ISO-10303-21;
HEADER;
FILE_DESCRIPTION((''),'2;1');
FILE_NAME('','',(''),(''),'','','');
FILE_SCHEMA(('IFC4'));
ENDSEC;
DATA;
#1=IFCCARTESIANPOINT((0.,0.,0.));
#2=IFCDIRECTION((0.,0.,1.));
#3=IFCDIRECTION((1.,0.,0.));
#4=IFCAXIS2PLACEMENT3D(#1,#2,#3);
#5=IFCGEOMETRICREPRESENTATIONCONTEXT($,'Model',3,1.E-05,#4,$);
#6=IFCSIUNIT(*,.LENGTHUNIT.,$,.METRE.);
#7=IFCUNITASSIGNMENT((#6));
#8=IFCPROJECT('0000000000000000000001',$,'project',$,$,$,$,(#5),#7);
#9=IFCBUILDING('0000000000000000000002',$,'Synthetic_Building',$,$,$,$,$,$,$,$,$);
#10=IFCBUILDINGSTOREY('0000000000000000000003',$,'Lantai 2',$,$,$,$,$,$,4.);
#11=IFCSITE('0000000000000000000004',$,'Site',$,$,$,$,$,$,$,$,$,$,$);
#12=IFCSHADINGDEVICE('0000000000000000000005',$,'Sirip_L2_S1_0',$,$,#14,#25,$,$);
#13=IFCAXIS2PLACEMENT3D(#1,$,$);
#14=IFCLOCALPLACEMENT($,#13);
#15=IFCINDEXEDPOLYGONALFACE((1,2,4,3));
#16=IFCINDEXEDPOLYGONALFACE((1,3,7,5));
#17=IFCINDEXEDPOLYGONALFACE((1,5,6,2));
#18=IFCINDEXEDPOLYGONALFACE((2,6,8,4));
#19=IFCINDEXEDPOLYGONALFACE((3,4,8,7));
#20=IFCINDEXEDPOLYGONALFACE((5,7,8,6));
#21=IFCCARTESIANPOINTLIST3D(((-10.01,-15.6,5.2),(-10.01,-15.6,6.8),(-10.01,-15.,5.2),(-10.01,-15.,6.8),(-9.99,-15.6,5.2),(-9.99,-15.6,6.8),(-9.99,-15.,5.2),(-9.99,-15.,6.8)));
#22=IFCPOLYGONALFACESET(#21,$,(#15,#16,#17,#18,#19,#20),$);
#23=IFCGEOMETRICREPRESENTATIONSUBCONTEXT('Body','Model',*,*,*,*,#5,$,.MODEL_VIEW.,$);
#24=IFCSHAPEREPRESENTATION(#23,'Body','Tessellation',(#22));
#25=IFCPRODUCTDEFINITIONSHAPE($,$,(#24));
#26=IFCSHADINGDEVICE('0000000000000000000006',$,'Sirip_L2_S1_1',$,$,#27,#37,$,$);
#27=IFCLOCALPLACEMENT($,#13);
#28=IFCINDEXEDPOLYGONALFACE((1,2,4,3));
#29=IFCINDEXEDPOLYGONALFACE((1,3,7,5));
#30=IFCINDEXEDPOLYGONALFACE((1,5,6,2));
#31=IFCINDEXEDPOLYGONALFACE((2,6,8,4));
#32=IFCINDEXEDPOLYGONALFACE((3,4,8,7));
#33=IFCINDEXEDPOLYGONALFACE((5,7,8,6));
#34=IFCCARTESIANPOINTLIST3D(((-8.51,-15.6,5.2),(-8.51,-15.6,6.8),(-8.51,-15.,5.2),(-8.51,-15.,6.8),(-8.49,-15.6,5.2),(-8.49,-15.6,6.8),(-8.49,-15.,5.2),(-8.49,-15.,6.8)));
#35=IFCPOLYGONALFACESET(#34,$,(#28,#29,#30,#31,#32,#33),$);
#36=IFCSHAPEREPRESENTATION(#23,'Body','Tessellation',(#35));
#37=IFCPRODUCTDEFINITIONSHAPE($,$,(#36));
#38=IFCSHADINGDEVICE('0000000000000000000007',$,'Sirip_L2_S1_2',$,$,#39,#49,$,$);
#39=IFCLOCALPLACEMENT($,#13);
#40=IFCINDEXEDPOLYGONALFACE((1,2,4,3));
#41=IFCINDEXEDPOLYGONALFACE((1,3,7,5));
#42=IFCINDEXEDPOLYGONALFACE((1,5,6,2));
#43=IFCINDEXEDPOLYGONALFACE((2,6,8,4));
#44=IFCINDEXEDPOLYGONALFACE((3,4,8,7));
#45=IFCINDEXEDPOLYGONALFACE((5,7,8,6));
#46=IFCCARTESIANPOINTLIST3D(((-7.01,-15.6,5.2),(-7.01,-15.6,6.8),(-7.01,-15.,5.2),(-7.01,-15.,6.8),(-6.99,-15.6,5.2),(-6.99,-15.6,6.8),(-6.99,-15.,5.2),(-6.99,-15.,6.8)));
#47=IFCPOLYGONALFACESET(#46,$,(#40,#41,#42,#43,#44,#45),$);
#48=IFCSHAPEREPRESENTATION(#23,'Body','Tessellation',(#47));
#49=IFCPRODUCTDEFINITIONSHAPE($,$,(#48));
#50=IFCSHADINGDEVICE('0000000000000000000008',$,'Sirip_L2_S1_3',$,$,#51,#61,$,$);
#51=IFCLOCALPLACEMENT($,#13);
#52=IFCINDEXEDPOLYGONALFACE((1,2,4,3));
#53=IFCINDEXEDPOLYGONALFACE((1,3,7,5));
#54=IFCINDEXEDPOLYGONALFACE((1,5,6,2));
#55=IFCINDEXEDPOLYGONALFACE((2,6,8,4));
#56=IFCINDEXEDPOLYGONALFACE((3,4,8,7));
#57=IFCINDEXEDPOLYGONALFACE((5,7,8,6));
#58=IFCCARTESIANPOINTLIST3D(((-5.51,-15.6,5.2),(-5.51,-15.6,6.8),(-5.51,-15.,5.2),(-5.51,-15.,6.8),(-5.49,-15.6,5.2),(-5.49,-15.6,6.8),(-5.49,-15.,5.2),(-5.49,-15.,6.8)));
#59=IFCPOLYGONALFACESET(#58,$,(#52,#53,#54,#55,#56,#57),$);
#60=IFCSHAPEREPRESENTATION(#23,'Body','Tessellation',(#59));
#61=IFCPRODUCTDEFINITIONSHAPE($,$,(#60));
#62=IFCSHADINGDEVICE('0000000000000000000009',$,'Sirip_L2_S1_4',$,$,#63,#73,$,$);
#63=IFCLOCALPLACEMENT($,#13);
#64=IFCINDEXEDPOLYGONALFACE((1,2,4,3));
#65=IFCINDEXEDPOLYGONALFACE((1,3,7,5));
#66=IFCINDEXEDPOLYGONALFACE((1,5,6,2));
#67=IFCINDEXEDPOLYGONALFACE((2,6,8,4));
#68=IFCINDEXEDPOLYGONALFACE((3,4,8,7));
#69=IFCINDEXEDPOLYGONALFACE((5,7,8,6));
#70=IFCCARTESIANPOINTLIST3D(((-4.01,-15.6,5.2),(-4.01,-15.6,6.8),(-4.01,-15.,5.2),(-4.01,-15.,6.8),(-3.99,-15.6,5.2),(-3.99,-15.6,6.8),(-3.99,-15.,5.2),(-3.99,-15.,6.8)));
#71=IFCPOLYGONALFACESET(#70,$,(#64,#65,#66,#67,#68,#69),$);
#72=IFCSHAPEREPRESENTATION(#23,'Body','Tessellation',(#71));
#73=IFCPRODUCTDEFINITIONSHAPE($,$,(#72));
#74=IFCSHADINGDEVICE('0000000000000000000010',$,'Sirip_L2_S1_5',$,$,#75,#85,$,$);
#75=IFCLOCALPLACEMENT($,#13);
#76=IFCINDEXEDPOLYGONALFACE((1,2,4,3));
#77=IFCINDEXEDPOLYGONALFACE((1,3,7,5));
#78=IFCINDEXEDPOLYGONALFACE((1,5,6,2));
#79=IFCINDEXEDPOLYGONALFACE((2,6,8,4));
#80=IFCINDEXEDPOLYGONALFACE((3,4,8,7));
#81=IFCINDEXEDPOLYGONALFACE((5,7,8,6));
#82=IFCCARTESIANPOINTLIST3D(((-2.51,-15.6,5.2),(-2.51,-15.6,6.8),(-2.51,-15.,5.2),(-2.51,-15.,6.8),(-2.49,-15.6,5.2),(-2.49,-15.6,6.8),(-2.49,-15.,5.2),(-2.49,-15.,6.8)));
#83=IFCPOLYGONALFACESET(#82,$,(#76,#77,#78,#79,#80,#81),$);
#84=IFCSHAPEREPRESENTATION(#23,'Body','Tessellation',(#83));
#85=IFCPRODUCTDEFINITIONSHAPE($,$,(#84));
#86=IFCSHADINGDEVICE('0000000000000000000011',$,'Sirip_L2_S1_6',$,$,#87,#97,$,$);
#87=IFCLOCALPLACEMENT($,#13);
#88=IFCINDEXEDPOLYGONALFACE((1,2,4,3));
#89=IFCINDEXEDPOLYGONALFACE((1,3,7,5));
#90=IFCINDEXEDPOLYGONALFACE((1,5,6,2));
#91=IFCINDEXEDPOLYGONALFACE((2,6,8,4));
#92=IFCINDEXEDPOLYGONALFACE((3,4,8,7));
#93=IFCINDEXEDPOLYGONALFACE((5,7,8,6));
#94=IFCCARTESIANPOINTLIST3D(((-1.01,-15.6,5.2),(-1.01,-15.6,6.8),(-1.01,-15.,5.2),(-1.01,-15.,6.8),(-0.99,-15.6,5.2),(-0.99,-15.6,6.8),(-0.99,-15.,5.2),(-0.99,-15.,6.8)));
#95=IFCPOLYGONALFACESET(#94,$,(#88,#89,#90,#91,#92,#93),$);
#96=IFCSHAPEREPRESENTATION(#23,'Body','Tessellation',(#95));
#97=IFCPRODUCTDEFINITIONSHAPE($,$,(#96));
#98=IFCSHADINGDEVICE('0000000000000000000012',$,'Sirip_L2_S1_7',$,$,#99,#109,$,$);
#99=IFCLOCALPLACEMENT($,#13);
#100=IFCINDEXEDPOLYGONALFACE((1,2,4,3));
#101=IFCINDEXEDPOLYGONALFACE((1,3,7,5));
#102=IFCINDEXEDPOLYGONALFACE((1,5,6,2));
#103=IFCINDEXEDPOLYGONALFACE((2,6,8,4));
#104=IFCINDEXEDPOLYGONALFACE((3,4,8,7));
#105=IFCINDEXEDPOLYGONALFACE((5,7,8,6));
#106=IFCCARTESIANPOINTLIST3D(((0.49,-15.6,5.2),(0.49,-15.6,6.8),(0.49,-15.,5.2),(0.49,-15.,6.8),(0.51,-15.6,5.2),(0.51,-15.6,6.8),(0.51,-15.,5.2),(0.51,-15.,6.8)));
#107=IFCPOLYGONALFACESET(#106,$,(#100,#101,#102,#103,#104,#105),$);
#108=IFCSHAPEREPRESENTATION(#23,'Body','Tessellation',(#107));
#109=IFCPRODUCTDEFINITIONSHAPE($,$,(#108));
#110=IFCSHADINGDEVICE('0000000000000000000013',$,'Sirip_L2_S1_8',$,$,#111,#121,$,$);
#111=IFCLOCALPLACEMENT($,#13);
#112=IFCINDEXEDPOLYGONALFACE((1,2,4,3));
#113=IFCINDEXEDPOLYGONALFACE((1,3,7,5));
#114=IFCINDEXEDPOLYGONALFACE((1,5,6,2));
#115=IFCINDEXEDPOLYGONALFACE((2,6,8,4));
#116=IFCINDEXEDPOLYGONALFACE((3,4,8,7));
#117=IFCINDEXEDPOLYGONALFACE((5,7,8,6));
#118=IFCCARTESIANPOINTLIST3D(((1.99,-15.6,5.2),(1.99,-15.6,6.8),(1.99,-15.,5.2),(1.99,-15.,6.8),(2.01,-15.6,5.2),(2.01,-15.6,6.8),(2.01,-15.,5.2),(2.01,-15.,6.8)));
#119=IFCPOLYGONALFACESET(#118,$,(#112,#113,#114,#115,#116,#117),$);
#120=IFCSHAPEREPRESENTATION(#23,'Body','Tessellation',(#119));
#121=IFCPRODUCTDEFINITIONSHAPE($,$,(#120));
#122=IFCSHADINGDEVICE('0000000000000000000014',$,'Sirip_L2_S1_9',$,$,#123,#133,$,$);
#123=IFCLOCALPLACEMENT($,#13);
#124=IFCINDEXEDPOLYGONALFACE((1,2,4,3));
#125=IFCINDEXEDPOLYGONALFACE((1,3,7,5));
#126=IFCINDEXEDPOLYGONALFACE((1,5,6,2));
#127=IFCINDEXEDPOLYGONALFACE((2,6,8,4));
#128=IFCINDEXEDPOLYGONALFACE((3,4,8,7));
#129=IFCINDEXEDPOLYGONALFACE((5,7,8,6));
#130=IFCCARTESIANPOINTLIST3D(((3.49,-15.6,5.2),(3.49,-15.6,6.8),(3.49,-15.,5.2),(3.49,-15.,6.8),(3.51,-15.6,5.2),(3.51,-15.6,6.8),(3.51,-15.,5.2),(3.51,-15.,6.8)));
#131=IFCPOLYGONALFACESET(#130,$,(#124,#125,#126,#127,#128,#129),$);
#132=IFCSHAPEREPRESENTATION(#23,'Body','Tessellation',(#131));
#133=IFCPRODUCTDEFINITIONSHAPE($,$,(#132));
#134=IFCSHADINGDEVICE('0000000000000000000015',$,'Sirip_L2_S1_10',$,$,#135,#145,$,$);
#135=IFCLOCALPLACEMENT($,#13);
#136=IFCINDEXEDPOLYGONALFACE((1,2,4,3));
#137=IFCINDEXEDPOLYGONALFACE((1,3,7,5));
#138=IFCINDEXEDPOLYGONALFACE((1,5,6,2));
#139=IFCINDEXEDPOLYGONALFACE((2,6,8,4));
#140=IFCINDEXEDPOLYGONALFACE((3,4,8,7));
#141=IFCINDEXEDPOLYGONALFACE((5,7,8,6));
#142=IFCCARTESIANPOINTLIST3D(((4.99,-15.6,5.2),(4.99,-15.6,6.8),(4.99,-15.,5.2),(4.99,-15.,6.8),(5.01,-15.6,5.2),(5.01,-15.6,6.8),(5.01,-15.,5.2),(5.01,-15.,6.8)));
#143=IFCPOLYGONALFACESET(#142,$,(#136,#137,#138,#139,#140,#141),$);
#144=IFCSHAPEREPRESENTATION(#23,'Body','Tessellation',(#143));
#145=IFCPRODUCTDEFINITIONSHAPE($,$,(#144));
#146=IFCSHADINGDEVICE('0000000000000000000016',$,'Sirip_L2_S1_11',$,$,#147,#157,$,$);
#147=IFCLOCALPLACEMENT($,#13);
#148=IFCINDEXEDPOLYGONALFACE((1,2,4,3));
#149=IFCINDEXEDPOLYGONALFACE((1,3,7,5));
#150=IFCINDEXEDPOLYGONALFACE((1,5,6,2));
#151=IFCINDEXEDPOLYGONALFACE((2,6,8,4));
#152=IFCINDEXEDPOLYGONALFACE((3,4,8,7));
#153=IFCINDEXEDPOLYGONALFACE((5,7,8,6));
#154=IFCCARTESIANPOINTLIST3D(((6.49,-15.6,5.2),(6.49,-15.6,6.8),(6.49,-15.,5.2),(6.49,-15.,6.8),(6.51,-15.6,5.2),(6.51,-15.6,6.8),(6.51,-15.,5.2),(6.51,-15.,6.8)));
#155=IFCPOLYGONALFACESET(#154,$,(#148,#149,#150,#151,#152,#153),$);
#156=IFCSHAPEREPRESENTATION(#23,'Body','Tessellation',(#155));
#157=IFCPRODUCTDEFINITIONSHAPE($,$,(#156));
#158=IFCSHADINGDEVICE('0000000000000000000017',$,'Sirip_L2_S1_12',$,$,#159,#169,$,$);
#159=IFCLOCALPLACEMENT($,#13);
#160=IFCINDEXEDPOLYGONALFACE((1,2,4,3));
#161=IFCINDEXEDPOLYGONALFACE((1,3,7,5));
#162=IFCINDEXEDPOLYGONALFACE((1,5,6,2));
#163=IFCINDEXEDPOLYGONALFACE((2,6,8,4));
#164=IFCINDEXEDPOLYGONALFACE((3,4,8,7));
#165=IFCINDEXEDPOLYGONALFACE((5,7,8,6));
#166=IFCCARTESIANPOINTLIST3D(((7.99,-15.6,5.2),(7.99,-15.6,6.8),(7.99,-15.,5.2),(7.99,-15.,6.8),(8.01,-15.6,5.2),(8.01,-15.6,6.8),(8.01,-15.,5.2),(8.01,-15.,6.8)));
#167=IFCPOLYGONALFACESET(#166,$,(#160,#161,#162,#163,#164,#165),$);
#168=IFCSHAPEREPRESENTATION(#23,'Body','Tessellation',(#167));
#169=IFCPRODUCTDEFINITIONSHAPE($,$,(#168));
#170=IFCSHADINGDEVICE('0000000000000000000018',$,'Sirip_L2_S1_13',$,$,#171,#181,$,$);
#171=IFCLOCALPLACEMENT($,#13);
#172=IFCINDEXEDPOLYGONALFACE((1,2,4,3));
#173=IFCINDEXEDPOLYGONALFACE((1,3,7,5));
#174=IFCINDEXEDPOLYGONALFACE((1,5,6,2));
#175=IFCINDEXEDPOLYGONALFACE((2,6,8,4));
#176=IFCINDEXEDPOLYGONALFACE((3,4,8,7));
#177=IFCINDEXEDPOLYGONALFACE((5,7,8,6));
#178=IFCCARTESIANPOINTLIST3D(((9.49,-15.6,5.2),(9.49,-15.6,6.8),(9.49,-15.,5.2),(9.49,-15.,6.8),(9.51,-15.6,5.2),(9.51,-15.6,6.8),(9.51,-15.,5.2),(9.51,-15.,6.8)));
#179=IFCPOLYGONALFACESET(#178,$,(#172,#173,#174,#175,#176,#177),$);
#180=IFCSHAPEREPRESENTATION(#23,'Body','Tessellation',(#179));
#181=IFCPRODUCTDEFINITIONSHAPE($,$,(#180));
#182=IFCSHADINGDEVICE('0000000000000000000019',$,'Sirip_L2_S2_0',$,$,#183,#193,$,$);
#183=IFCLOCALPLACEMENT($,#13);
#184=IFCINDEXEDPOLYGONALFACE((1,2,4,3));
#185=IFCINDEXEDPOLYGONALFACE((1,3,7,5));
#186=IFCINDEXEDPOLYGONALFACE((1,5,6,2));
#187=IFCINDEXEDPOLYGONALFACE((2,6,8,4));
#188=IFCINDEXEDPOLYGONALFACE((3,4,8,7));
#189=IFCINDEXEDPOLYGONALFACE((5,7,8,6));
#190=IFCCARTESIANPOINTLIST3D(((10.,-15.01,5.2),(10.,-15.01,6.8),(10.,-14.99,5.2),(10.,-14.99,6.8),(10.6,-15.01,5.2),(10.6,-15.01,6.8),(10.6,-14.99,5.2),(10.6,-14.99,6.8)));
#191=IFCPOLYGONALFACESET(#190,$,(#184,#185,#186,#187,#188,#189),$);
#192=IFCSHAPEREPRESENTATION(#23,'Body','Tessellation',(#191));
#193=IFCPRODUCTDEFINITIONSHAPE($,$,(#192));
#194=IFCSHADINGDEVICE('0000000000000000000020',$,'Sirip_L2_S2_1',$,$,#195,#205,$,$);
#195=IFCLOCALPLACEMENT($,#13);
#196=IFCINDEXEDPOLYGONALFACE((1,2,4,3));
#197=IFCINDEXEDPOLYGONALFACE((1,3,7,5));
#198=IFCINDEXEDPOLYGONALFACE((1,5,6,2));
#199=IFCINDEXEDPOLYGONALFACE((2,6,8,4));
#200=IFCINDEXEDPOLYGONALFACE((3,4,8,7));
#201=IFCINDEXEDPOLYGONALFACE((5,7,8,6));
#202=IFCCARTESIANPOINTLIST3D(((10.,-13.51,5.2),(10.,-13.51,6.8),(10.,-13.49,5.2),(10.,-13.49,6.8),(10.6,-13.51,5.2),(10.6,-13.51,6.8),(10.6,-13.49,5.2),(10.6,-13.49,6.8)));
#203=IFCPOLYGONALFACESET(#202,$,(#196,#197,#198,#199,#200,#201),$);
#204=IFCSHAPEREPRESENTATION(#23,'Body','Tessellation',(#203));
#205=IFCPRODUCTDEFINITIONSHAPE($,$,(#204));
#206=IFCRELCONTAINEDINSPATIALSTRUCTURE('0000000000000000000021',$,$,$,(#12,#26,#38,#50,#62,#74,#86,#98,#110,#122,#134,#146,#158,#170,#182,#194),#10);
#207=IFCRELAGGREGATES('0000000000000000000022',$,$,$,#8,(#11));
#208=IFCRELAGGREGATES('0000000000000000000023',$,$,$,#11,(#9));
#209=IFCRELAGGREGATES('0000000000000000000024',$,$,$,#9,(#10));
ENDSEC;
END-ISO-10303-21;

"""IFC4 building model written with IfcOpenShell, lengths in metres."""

from ifc_helpers import new_model, si_unit, frame, origin_with_axes, place, context, subcontext, project, spatial, polyline, outline, extrude, element, save


model = new_model("IFC4")

# Units and contexts
model_context = context("Model", 3, precision=1e-05, world=origin_with_axes())
body_context = subcontext(model_context, "Body", "Model", "MODEL_VIEW")
ifc_project = project(units=[si_unit("LENGTHUNIT", "METRE")], contexts=[model_context])

# Site, building, storey
site = spatial("IfcSite", under=ifc_project, Name="Site")
building = spatial("IfcBuilding", under=site, Name="Synthetic_Building")
storey = spatial("IfcBuildingStorey", under=building, Name="Lantai 2", Elevation=4.0)

# Shading devices
shading_device_1_placement = place(None, origin_with_axes())
element("IfcShadingDevice", 1, at=shading_device_1_placement, inside=storey, Name="Sirip_L2_S1_0", context=body_context, shape_type="SweptSolid", body=[
    extrude(outline(polyline([(-10.01, -15.0), (-9.99, -15.0), (-9.99, -15.6), (-10.01, -15.6), (-10.01, -15.0)])), frame((0.0, 0.0, 5.2), z_axis=(0.0, 0.0, 1.0), x_axis=(1.0, 0.0, 0.0)), (0.0, 0.0, 1.0), 1.6),
])
shading_device_2_placement = place(None, origin_with_axes())
element("IfcShadingDevice", 2, at=shading_device_2_placement, inside=storey, Name="Sirip_L2_S1_1", context=body_context, shape_type="SweptSolid", body=[
    extrude(outline(polyline([(-8.51, -15.0), (-8.49, -15.0), (-8.49, -15.6), (-8.51, -15.6), (-8.51, -15.0)])), frame((0.0, 0.0, 5.2), z_axis=(0.0, 0.0, 1.0), x_axis=(1.0, 0.0, 0.0)), (0.0, 0.0, 1.0), 1.6),
])
shading_device_3_placement = place(None, origin_with_axes())
element("IfcShadingDevice", 3, at=shading_device_3_placement, inside=storey, Name="Sirip_L2_S1_2", context=body_context, shape_type="SweptSolid", body=[
    extrude(outline(polyline([(-7.01, -15.0), (-6.99, -15.0), (-6.99, -15.6), (-7.01, -15.6), (-7.01, -15.0)])), frame((0.0, 0.0, 5.2), z_axis=(0.0, 0.0, 1.0), x_axis=(1.0, 0.0, 0.0)), (0.0, 0.0, 1.0), 1.6),
])
shading_device_4_placement = place(None, origin_with_axes())
element("IfcShadingDevice", 4, at=shading_device_4_placement, inside=storey, Name="Sirip_L2_S1_3", context=body_context, shape_type="SweptSolid", body=[
    extrude(outline(polyline([(-5.51, -15.0), (-5.49, -15.0), (-5.49, -15.6), (-5.51, -15.6), (-5.51, -15.0)])), frame((0.0, 0.0, 5.2), z_axis=(0.0, 0.0, 1.0), x_axis=(1.0, 0.0, 0.0)), (0.0, 0.0, 1.0), 1.6),
])
shading_device_5_placement = place(None, origin_with_axes())
element("IfcShadingDevice", 5, at=shading_device_5_placement, inside=storey, Name="Sirip_L2_S1_4", context=body_context, shape_type="SweptSolid", body=[
    extrude(outline(polyline([(-4.01, -15.0), (-3.99, -15.0), (-3.99, -15.6), (-4.01, -15.6), (-4.01, -15.0)])), frame((0.0, 0.0, 5.2), z_axis=(0.0, 0.0, 1.0), x_axis=(1.0, 0.0, 0.0)), (0.0, 0.0, 1.0), 1.6),
])
shading_device_6_placement = place(None, origin_with_axes())
element("IfcShadingDevice", 6, at=shading_device_6_placement, inside=storey, Name="Sirip_L2_S1_5", context=body_context, shape_type="SweptSolid", body=[
    extrude(outline(polyline([(-2.51, -15.0), (-2.49, -15.0), (-2.49, -15.6), (-2.51, -15.6), (-2.51, -15.0)])), frame((0.0, 0.0, 5.2), z_axis=(0.0, 0.0, 1.0), x_axis=(1.0, 0.0, 0.0)), (0.0, 0.0, 1.0), 1.6),
])
shading_device_7_placement = place(None, origin_with_axes())
element("IfcShadingDevice", 7, at=shading_device_7_placement, inside=storey, Name="Sirip_L2_S1_6", context=body_context, shape_type="SweptSolid", body=[
    extrude(outline(polyline([(-1.01, -15.0), (-0.99, -15.0), (-0.99, -15.6), (-1.01, -15.6), (-1.01, -15.0)])), frame((0.0, 0.0, 5.2), z_axis=(0.0, 0.0, 1.0), x_axis=(1.0, 0.0, 0.0)), (0.0, 0.0, 1.0), 1.6),
])
shading_device_8_placement = place(None, origin_with_axes())
element("IfcShadingDevice", 8, at=shading_device_8_placement, inside=storey, Name="Sirip_L2_S1_7", context=body_context, shape_type="SweptSolid", body=[
    extrude(outline(polyline([(0.49, -15.0), (0.51, -15.0), (0.51, -15.6), (0.49, -15.6), (0.49, -15.0)])), frame((0.0, 0.0, 5.2), z_axis=(0.0, 0.0, 1.0), x_axis=(1.0, 0.0, 0.0)), (0.0, 0.0, 1.0), 1.6),
])
shading_device_9_placement = place(None, origin_with_axes())
element("IfcShadingDevice", 9, at=shading_device_9_placement, inside=storey, Name="Sirip_L2_S1_8", context=body_context, shape_type="SweptSolid", body=[
    extrude(outline(polyline([(1.99, -15.0), (2.01, -15.0), (2.01, -15.6), (1.99, -15.6), (1.99, -15.0)])), frame((0.0, 0.0, 5.2), z_axis=(0.0, 0.0, 1.0), x_axis=(1.0, 0.0, 0.0)), (0.0, 0.0, 1.0), 1.6),
])
shading_device_10_placement = place(None, origin_with_axes())
element("IfcShadingDevice", 10, at=shading_device_10_placement, inside=storey, Name="Sirip_L2_S1_9", context=body_context, shape_type="SweptSolid", body=[
    extrude(outline(polyline([(3.49, -15.0), (3.51, -15.0), (3.51, -15.6), (3.49, -15.6), (3.49, -15.0)])), frame((0.0, 0.0, 5.2), z_axis=(0.0, 0.0, 1.0), x_axis=(1.0, 0.0, 0.0)), (0.0, 0.0, 1.0), 1.6),
])
shading_device_11_placement = place(None, origin_with_axes())
element("IfcShadingDevice", 11, at=shading_device_11_placement, inside=storey, Name="Sirip_L2_S1_10", context=body_context, shape_type="SweptSolid", body=[
    extrude(outline(polyline([(4.99, -15.0), (5.01, -15.0), (5.01, -15.6), (4.99, -15.6), (4.99, -15.0)])), frame((0.0, 0.0, 5.2), z_axis=(0.0, 0.0, 1.0), x_axis=(1.0, 0.0, 0.0)), (0.0, 0.0, 1.0), 1.6),
])
shading_device_12_placement = place(None, origin_with_axes())
element("IfcShadingDevice", 12, at=shading_device_12_placement, inside=storey, Name="Sirip_L2_S1_11", context=body_context, shape_type="SweptSolid", body=[
    extrude(outline(polyline([(6.49, -15.0), (6.51, -15.0), (6.51, -15.6), (6.49, -15.6), (6.49, -15.0)])), frame((0.0, 0.0, 5.2), z_axis=(0.0, 0.0, 1.0), x_axis=(1.0, 0.0, 0.0)), (0.0, 0.0, 1.0), 1.6),
])
shading_device_13_placement = place(None, origin_with_axes())
element("IfcShadingDevice", 13, at=shading_device_13_placement, inside=storey, Name="Sirip_L2_S1_12", context=body_context, shape_type="SweptSolid", body=[
    extrude(outline(polyline([(7.99, -15.0), (8.01, -15.0), (8.01, -15.6), (7.99, -15.6), (7.99, -15.0)])), frame((0.0, 0.0, 5.2), z_axis=(0.0, 0.0, 1.0), x_axis=(1.0, 0.0, 0.0)), (0.0, 0.0, 1.0), 1.6),
])
shading_device_14_placement = place(None, origin_with_axes())
element("IfcShadingDevice", 14, at=shading_device_14_placement, inside=storey, Name="Sirip_L2_S1_13", context=body_context, shape_type="SweptSolid", body=[
    extrude(outline(polyline([(9.49, -15.0), (9.51, -15.0), (9.51, -15.6), (9.49, -15.6), (9.49, -15.0)])), frame((0.0, 0.0, 5.2), z_axis=(0.0, 0.0, 1.0), x_axis=(1.0, 0.0, 0.0)), (0.0, 0.0, 1.0), 1.6),
])
shading_device_15_placement = place(None, origin_with_axes())
element("IfcShadingDevice", 15, at=shading_device_15_placement, inside=storey, Name="Sirip_L2_S2_0", context=body_context, shape_type="SweptSolid", body=[
    extrude(outline(polyline([(10.0, -15.01), (10.0, -14.99), (10.6, -14.99), (10.6, -15.01), (10.0, -15.01)])), frame((0.0, 0.0, 5.2), z_axis=(0.0, 0.0, 1.0), x_axis=(1.0, 0.0, 0.0)), (0.0, 0.0, 1.0), 1.6),
])
shading_device_16_placement = place(None, origin_with_axes())
element("IfcShadingDevice", 16, at=shading_device_16_placement, inside=storey, Name="Sirip_L2_S2_1", context=body_context, shape_type="SweptSolid", body=[
    extrude(outline(polyline([(10.0, -13.51), (10.0, -13.49), (10.6, -13.49), (10.6, -13.51), (10.0, -13.51)])), frame((0.0, 0.0, 5.2), z_axis=(0.0, 0.0, 1.0), x_axis=(1.0, 0.0, 0.0)), (0.0, 0.0, 1.0), 1.6),
])

save(model, "model.ifc")
